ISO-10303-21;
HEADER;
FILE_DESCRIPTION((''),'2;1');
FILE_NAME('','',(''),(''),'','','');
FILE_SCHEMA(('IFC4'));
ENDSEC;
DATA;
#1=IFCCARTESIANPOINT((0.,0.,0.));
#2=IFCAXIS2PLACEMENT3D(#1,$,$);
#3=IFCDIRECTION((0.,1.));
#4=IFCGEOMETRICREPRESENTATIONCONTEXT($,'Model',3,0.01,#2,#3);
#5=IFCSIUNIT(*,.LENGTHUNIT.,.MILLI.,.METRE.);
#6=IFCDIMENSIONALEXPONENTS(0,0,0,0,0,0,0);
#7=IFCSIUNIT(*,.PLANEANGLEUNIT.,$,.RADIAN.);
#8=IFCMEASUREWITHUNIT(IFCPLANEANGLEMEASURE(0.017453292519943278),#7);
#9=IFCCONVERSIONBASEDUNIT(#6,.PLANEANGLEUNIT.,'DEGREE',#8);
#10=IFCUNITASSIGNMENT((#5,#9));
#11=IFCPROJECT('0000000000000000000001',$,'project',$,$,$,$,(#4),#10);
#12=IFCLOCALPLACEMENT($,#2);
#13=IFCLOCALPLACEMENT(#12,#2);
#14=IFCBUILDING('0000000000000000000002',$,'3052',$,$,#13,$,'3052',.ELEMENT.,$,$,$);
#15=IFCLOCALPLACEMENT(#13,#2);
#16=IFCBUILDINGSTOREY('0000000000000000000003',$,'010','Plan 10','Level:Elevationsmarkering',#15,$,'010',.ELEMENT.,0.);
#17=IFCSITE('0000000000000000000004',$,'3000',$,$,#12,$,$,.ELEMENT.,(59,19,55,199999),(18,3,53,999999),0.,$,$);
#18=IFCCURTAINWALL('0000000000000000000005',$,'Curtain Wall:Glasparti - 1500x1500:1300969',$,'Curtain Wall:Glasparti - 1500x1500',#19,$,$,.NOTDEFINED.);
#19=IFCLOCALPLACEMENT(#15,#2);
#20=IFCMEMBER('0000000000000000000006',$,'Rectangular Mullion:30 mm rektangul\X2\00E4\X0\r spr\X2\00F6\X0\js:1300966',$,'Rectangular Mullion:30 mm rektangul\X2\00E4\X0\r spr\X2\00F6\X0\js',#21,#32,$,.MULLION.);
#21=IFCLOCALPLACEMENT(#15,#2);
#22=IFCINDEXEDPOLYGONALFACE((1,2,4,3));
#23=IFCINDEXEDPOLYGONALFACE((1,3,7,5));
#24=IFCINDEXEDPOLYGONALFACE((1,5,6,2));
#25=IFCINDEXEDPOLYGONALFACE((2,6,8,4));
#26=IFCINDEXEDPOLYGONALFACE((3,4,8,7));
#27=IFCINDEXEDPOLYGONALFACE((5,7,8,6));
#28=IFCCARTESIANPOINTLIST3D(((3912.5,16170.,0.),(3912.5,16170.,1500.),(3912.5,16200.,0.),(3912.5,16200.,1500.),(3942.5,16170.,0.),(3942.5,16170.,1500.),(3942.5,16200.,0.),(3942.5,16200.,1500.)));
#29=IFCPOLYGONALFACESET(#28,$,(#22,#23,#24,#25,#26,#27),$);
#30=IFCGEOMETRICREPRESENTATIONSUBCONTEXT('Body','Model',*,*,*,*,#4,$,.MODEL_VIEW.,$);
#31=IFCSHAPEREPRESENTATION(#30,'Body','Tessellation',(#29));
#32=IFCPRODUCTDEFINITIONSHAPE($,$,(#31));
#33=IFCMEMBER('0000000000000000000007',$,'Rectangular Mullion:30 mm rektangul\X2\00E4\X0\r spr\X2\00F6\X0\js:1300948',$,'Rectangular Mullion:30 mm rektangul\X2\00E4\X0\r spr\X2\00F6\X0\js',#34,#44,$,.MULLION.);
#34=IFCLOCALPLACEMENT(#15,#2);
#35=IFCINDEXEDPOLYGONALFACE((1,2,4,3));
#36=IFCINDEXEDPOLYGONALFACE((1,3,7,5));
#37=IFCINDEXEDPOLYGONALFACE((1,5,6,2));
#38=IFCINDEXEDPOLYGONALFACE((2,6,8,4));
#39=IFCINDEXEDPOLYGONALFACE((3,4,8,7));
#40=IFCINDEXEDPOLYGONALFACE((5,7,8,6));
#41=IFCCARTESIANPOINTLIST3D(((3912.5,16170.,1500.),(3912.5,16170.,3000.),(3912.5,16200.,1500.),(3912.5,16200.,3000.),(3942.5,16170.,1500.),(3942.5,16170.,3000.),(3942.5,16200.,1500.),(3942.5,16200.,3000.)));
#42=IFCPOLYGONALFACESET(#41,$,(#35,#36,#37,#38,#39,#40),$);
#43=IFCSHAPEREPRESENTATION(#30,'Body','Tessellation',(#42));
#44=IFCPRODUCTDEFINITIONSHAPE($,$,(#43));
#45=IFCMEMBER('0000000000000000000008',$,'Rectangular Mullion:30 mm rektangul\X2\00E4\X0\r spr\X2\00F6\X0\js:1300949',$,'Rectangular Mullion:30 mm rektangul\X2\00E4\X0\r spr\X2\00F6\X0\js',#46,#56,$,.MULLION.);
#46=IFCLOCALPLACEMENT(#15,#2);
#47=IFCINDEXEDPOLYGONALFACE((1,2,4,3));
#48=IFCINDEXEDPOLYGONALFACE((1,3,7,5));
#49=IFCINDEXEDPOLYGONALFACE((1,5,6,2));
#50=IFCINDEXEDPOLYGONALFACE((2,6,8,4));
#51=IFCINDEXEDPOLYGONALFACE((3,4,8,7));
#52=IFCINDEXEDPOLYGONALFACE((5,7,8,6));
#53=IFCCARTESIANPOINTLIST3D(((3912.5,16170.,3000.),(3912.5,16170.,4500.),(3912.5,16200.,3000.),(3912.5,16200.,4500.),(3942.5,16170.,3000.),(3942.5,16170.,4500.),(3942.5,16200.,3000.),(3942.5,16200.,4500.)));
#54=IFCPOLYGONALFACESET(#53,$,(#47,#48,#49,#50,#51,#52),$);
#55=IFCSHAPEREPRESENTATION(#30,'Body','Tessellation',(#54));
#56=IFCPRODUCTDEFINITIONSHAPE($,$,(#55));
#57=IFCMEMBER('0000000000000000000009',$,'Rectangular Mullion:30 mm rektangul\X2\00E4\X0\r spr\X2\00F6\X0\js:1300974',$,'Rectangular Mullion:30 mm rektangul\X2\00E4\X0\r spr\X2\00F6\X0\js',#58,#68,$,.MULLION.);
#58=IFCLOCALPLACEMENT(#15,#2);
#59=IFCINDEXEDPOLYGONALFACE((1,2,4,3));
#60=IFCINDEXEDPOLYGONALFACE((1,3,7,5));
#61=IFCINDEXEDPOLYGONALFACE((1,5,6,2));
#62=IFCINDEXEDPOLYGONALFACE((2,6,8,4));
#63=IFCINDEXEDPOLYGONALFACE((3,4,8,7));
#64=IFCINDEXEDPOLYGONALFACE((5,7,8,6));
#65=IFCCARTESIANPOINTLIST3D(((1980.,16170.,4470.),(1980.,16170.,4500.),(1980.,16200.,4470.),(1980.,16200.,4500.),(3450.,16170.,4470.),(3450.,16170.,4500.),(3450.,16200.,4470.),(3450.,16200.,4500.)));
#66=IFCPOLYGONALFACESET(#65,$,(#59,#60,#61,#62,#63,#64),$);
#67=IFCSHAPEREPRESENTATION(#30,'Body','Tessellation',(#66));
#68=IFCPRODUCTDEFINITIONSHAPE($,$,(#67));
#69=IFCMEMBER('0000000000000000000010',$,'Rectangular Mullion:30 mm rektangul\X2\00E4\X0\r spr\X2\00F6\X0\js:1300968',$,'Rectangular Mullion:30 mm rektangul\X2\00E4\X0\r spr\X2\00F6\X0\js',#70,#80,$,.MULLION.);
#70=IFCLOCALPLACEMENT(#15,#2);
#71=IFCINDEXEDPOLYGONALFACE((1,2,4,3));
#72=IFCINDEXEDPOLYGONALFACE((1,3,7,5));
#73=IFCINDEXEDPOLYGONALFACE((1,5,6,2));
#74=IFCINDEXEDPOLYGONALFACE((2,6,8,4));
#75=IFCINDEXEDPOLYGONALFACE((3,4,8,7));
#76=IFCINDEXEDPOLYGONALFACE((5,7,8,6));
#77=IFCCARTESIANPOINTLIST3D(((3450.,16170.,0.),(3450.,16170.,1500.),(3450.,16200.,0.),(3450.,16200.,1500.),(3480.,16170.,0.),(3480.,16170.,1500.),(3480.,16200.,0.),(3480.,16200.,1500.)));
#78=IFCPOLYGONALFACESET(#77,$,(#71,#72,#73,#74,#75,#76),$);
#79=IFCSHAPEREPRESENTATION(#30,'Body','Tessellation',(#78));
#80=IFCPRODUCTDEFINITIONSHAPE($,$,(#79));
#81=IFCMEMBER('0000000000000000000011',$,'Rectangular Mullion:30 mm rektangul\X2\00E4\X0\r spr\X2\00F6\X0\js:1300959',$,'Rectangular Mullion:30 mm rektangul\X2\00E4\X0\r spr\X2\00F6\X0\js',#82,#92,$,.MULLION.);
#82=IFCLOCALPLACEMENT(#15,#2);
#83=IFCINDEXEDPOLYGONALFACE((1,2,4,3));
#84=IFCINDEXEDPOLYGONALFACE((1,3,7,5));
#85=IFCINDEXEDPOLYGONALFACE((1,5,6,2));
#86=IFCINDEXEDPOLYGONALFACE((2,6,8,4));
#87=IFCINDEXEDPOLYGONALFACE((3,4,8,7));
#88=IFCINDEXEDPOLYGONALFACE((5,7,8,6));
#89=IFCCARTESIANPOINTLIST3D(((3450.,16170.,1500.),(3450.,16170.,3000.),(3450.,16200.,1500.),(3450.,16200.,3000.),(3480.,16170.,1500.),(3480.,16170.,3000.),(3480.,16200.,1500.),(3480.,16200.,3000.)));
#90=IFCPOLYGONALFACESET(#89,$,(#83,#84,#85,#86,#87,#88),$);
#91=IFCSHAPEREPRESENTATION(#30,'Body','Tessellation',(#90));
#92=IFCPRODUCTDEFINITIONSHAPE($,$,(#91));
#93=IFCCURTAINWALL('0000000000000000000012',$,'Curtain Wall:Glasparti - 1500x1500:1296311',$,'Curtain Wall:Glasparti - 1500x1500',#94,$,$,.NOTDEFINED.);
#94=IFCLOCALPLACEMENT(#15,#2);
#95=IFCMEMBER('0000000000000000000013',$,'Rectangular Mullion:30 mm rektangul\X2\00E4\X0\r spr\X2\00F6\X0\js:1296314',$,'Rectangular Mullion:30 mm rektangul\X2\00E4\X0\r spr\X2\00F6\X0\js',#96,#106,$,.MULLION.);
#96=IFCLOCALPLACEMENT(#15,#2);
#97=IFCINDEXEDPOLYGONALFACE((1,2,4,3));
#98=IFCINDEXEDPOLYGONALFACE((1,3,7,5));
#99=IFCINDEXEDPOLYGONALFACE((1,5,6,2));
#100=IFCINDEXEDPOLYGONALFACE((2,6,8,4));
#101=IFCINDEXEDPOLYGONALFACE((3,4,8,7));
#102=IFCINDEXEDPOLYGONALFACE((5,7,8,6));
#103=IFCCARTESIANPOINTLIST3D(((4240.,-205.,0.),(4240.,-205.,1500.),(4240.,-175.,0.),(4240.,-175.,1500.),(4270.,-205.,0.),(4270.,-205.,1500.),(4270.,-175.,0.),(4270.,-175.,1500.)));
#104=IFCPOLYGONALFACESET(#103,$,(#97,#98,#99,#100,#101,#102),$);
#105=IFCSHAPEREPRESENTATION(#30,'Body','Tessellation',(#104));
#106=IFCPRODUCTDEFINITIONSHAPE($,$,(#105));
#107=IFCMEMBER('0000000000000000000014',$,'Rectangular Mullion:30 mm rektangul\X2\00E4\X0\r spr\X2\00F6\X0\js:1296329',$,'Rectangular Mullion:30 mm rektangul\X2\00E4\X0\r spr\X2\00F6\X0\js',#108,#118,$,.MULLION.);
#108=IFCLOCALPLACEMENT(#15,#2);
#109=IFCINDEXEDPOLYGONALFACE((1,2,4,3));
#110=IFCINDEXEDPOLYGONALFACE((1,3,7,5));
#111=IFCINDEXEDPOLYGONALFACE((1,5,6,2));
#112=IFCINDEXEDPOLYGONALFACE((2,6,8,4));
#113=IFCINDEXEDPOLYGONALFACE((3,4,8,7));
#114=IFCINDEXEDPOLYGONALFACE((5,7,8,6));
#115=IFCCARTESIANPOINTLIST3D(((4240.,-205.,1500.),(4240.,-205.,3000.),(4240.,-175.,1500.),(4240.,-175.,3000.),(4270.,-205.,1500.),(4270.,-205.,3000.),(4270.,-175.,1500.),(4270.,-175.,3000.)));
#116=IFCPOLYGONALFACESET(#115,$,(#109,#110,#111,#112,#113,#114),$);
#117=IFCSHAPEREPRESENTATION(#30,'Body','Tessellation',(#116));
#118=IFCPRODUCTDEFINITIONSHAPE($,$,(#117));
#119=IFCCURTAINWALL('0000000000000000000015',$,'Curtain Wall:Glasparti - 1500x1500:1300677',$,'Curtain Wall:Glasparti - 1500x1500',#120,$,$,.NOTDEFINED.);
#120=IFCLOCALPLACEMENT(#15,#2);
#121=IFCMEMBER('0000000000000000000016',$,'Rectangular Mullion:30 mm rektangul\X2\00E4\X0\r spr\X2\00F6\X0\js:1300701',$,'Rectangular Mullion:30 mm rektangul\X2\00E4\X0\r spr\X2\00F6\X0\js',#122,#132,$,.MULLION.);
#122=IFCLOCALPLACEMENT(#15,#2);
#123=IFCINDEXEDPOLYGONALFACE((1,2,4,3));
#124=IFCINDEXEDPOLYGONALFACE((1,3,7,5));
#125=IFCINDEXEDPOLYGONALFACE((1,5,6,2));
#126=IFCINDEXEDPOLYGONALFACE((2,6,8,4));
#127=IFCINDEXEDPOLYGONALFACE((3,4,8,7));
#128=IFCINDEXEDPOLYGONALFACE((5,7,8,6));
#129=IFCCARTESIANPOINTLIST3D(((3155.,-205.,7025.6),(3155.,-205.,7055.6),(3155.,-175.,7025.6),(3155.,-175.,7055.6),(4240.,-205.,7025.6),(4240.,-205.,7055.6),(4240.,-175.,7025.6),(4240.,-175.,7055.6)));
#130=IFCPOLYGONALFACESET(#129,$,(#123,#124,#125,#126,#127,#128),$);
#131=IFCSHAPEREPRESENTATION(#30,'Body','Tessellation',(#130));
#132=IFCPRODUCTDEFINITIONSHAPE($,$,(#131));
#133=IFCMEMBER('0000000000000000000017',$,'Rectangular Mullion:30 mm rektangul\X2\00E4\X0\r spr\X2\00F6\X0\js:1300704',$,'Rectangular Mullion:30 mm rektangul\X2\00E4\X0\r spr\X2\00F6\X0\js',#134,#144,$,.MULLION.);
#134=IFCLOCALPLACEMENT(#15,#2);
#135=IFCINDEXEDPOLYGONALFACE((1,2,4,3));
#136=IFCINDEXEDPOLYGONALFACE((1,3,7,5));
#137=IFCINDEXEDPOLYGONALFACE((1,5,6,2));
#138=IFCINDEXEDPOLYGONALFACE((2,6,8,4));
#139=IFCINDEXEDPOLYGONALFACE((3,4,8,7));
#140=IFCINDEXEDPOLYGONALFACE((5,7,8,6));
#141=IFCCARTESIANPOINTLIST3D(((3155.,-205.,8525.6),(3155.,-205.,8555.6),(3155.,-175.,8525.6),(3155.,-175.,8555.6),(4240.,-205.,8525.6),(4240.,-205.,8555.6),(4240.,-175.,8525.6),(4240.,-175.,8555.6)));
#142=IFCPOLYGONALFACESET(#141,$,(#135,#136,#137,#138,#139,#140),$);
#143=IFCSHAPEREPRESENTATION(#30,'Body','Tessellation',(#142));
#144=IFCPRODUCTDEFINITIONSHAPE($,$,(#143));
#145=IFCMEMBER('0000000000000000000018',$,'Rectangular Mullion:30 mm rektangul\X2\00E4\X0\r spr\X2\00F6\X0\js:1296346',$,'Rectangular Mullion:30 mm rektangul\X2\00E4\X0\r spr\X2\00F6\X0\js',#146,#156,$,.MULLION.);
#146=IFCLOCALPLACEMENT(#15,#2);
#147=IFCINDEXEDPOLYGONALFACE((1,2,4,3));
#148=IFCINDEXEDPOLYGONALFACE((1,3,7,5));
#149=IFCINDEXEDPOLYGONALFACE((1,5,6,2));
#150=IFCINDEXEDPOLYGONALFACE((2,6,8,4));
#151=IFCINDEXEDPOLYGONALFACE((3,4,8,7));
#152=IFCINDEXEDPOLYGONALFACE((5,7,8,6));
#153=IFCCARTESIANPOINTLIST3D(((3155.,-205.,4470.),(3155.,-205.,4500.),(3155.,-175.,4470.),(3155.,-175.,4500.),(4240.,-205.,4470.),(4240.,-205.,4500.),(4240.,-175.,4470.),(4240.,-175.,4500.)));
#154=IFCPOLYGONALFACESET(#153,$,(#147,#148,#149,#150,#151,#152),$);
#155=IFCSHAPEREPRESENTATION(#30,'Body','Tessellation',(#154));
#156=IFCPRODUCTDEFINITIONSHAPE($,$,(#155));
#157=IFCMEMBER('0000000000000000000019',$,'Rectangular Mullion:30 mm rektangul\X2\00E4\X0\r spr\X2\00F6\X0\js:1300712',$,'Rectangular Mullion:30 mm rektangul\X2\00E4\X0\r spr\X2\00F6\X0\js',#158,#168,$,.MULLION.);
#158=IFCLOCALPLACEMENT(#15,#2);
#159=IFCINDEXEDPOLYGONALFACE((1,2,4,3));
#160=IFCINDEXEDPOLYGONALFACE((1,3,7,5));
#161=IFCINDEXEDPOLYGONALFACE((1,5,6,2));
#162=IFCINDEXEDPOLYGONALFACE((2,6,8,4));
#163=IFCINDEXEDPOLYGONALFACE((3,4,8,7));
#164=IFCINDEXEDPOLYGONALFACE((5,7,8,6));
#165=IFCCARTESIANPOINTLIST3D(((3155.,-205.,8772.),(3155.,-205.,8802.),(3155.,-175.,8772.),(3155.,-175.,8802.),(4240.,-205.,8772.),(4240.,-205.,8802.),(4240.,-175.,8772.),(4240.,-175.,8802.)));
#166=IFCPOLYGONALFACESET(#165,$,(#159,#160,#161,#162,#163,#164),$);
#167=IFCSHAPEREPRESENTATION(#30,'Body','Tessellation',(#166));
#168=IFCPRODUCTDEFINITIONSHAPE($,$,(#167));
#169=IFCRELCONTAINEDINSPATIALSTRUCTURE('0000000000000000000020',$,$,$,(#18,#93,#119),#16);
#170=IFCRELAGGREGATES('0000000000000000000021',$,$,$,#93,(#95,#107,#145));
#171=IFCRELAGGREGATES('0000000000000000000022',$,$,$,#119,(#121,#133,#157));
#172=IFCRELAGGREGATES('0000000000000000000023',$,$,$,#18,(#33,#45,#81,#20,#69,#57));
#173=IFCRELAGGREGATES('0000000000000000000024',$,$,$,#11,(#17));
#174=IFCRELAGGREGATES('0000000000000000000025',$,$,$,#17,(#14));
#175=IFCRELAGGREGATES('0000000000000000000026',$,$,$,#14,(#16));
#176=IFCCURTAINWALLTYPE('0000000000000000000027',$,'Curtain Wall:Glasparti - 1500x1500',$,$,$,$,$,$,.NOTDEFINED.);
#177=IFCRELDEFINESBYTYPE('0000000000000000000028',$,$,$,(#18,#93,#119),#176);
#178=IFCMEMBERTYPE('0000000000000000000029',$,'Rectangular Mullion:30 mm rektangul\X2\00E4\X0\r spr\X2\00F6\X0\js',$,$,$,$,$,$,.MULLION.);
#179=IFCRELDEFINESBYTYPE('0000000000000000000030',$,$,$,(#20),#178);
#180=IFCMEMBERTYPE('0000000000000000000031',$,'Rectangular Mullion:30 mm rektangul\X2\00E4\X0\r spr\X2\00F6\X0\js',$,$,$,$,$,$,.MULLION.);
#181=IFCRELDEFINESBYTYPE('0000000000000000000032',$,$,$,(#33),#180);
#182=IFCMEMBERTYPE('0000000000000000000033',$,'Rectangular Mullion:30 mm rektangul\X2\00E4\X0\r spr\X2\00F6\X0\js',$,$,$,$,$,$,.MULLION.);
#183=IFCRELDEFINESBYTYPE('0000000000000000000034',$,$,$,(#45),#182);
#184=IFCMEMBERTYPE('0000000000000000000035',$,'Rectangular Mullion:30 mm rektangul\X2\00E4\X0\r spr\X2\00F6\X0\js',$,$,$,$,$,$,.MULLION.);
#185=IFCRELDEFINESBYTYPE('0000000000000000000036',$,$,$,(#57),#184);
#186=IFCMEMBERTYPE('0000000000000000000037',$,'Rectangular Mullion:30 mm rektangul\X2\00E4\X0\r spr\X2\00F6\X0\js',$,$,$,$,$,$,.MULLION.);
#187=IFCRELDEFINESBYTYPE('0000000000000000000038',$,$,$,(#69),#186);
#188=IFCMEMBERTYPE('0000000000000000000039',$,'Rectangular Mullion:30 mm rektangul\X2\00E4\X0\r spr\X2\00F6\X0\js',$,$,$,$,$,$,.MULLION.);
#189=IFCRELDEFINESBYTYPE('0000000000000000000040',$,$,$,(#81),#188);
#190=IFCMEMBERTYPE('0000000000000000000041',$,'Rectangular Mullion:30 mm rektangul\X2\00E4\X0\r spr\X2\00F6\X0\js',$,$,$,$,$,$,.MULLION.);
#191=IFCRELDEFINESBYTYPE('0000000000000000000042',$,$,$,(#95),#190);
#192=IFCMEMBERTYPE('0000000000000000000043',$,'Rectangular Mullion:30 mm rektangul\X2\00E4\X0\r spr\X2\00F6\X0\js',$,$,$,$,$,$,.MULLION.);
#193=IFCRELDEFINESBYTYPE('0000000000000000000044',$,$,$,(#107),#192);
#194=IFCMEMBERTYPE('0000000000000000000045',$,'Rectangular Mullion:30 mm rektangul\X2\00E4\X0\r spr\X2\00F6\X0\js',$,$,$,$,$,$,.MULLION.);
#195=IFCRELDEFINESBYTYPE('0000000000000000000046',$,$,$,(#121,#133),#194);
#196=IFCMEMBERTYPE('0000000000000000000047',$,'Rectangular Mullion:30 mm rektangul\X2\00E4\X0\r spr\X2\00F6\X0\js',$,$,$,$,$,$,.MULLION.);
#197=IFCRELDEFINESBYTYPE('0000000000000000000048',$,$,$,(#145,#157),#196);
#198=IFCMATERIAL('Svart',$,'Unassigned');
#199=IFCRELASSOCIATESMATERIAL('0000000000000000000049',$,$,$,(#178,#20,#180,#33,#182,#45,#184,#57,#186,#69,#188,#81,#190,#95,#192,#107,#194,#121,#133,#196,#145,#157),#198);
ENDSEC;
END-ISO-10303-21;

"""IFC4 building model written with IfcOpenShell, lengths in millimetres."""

from ifc_helpers import new_model, entity, si_unit, converted_unit, direction, frame, origin, place, context, subcontext, project, spatial, indexed_curve, outline, extrude, source, transform, mapped, material, type_object, type_shapes, element, aggregate, save


model = new_model("IFC4")

# Units and contexts
model_context = context("Model", 3, precision=0.01, world=origin(), true_north=direction((0.0, 1.0)))
body_context = subcontext(model_context, "Body", "Model", "MODEL_VIEW")
ifc_project = project(units=[si_unit("LENGTHUNIT", "METRE", prefix="MILLI"), converted_unit("PLANEANGLEUNIT", "DEGREE", entity("IfcPlaneAngleMeasure", 0.017453292519943278), si_unit("PLANEANGLEUNIT", "RADIAN"), dimensions=[0, 0, 0, 0, 0, 0, 0])], contexts=[model_context])

# Site, building, storey
site_placement = place(None, origin())
site = spatial("IfcSite", under=ifc_project, at=site_placement, Name="3000", CompositionType="ELEMENT", RefLatitude=(59, 19, 55, 199999), RefLongitude=(18, 3, 53, 999999), RefElevation=0.0)
building_placement = place(site_placement, origin())
building = spatial("IfcBuilding", under=site, at=building_placement, Name="3052", LongName="3052", CompositionType="ELEMENT")
storey_placement = place(building_placement, origin())
storey = spatial("IfcBuildingStorey", under=building, at=storey_placement, Name="010", Description="Plan 10", ObjectType="Level:Elevationsmarkering", LongName="010", CompositionType="ELEMENT", Elevation=0.0)

# Curtain walls, members
curtain_wall_type = type_object("IfcCurtainWallType", Name="Curtain Wall:Glasparti - 1500x1500", PredefinedType="NOTDEFINED")
curtain_wall_1_placement = place(storey_placement, origin())
curtain_wall_1 = element("IfcCurtainWall", 1, at=curtain_wall_1_placement, inside=storey, type_object=curtain_wall_type, Name="Curtain Wall:Glasparti - 1500x1500:1300969", ObjectType="Curtain Wall:Glasparti - 1500x1500", PredefinedType="NOTDEFINED")
ifc_material_1 = material(Name="Svart", Category="Unassigned")
member_type_1 = type_object("IfcMemberType", Name="Rectangular Mullion:30 mm rektangulär spröjs", PredefinedType="MULLION", material=ifc_material_1)
shared_shape_1 = source(origin(), body_context, "Body", "SweptSolid", [
    extrude(outline(indexed_curve([(-15.0, -15.0), (15.0, -15.0), (15.0, 15.0), (-15.0, 15.0), (-15.0, -15.0)], self_intersect=False)), frame((-15.0, 0.0, -1500.0), z_axis=(0.0, 0.0, 1.0), x_axis=(-1.0, 0.0, 0.0)), (0.0, 0.0, 1.0), 1500.0),
])
type_shapes(member_type_1, [shared_shape_1])
member_1_placement = place(curtain_wall_1_placement, frame((3942.5, 16185.0, 0.0), z_axis=(0.0, 0.0, -1.0), x_axis=(1.0, 0.0, 0.0)))
member_1 = element("IfcMember", 2, at=member_1_placement, type_object=member_type_1, material=ifc_material_1, Name="Rectangular Mullion:30 mm rektangulär spröjs:1300966", ObjectType="Rectangular Mullion:30 mm rektangulär spröjs", PredefinedType="MULLION", context=body_context, shape_type="MappedRepresentation", body=[
    mapped(shared_shape_1, transform((0.0, 0.0, 0.0), scale=1.0)),
])
member_type_2 = type_object("IfcMemberType", Name="Rectangular Mullion:30 mm rektangulär spröjs", PredefinedType="MULLION", material=ifc_material_1)
shared_shape_2 = source(origin(), body_context, "Body", "SweptSolid", [
    extrude(outline(indexed_curve([(-15.0, -15.0), (15.0, -15.0), (15.0, 15.0), (-15.0, 15.0), (-15.0, -15.0)], self_intersect=False)), frame((-15.0, 0.0, -1500.0), z_axis=(0.0, 0.0, 1.0), x_axis=(-1.0, 0.0, 0.0)), (0.0, 0.0, 1.0), 1500.0),
])
type_shapes(member_type_2, [shared_shape_2])
member_2_placement = place(curtain_wall_1_placement, frame((3942.5, 16185.0, 1500.0), z_axis=(0.0, 0.0, -1.0), x_axis=(1.0, 0.0, 0.0)))
member_2 = element("IfcMember", 3, at=member_2_placement, type_object=member_type_2, material=ifc_material_1, Name="Rectangular Mullion:30 mm rektangulär spröjs:1300948", ObjectType="Rectangular Mullion:30 mm rektangulär spröjs", PredefinedType="MULLION", context=body_context, shape_type="MappedRepresentation", body=[
    mapped(shared_shape_2, transform((0.0, 0.0, 0.0), scale=1.0)),
])
member_type_3 = type_object("IfcMemberType", Name="Rectangular Mullion:30 mm rektangulär spröjs", PredefinedType="MULLION", material=ifc_material_1)
shared_shape_3 = source(origin(), body_context, "Body", "SweptSolid", [
    extrude(outline(indexed_curve([(-15.0, -15.0), (15.0, -15.0), (15.0, 15.0), (-15.0, 15.0), (-15.0, -15.0)], self_intersect=False)), frame((-15.0, 0.0, -1500.0), z_axis=(0.0, 0.0, 1.0), x_axis=(-1.0, 0.0, 0.0)), (0.0, 0.0, 1.0), 1500.0),
])
type_shapes(member_type_3, [shared_shape_3])
member_3_placement = place(curtain_wall_1_placement, frame((3942.5, 16185.0, 3000.0), z_axis=(0.0, 0.0, -1.0), x_axis=(1.0, 0.0, 0.0)))
member_3 = element("IfcMember", 4, at=member_3_placement, type_object=member_type_3, material=ifc_material_1, Name="Rectangular Mullion:30 mm rektangulär spröjs:1300949", ObjectType="Rectangular Mullion:30 mm rektangulär spröjs", PredefinedType="MULLION", context=body_context, shape_type="MappedRepresentation", body=[
    mapped(shared_shape_3, transform((0.0, 0.0, 0.0), scale=1.0)),
])
member_type_4 = type_object("IfcMemberType", Name="Rectangular Mullion:30 mm rektangulär spröjs", PredefinedType="MULLION", material=ifc_material_1)
shared_shape_4 = source(origin(), body_context, "Body", "SweptSolid", [
    extrude(outline(indexed_curve([(-15.0, -15.0), (15.0, -15.0), (15.0, 15.0), (-15.0, 15.0), (-15.0, -15.0)], self_intersect=False)), frame((-15.0, 0.0, -1470.0), z_axis=(0.0, 0.0, 1.0), x_axis=(-1.0, 0.0, 0.0)), (0.0, 0.0, 1.0), 1470.0),
])
type_shapes(member_type_4, [shared_shape_4])
member_4_placement = place(curtain_wall_1_placement, frame((3450.0, 16185.0, 4500.0), z_axis=(1.0, 0.0, 0.0), x_axis=(0.0, 0.0, 1.0)))
member_4 = element("IfcMember", 5, at=member_4_placement, type_object=member_type_4, material=ifc_material_1, Name="Rectangular Mullion:30 mm rektangulär spröjs:1300974", ObjectType="Rectangular Mullion:30 mm rektangulär spröjs", PredefinedType="MULLION", context=body_context, shape_type="MappedRepresentation", body=[
    mapped(shared_shape_4, transform((0.0, 0.0, 0.0), scale=1.0)),
])
member_type_5 = type_object("IfcMemberType", Name="Rectangular Mullion:30 mm rektangulär spröjs", PredefinedType="MULLION", material=ifc_material_1)
shared_shape_5 = source(origin(), body_context, "Body", "SweptSolid", [
    extrude(outline(indexed_curve([(-15.0, -15.0), (15.0, -15.0), (15.0, 15.0), (-15.0, 15.0), (-15.0, -15.0)], self_intersect=False)), frame((0.0, 0.0, -1500.0), z_axis=(0.0, 0.0, 1.0), x_axis=(-1.0, 0.0, 0.0)), (0.0, 0.0, 1.0), 1500.0),
])
type_shapes(member_type_5, [shared_shape_5])
member_5_placement = place(curtain_wall_1_placement, frame((3465.0, 16185.0, 0.0), z_axis=(0.0, 0.0, -1.0), x_axis=(1.0, 0.0, 0.0)))
member_5 = element("IfcMember", 6, at=member_5_placement, type_object=member_type_5, material=ifc_material_1, Name="Rectangular Mullion:30 mm rektangulär spröjs:1300968", ObjectType="Rectangular Mullion:30 mm rektangulär spröjs", PredefinedType="MULLION", context=body_context, shape_type="MappedRepresentation", body=[
    mapped(shared_shape_5, transform((0.0, 0.0, 0.0), scale=1.0)),
])
member_type_6 = type_object("IfcMemberType", Name="Rectangular Mullion:30 mm rektangulär spröjs", PredefinedType="MULLION", material=ifc_material_1)
shared_shape_6 = source(origin(), body_context, "Body", "SweptSolid", [
    extrude(outline(indexed_curve([(-15.0, -15.0), (15.0, -15.0), (15.0, 15.0), (-15.0, 15.0), (-15.0, -15.0)], self_intersect=False)), frame((0.0, 0.0, -1500.0), z_axis=(0.0, 0.0, 1.0), x_axis=(-1.0, 0.0, 0.0)), (0.0, 0.0, 1.0), 1500.0),
])
type_shapes(member_type_6, [shared_shape_6])
member_6_placement = place(curtain_wall_1_placement, frame((3465.0, 16185.0, 1500.0), z_axis=(0.0, 0.0, -1.0), x_axis=(1.0, 0.0, 0.0)))
member_6 = element("IfcMember", 7, at=member_6_placement, type_object=member_type_6, material=ifc_material_1, Name="Rectangular Mullion:30 mm rektangulär spröjs:1300959", ObjectType="Rectangular Mullion:30 mm rektangulär spröjs", PredefinedType="MULLION", context=body_context, shape_type="MappedRepresentation", body=[
    mapped(shared_shape_6, transform((0.0, 0.0, 0.0), scale=1.0)),
])
curtain_wall_2_placement = place(storey_placement, origin())
curtain_wall_2 = element("IfcCurtainWall", 8, at=curtain_wall_2_placement, inside=storey, type_object=curtain_wall_type, Name="Curtain Wall:Glasparti - 1500x1500:1296311", ObjectType="Curtain Wall:Glasparti - 1500x1500", PredefinedType="NOTDEFINED")
member_type_7 = type_object("IfcMemberType", Name="Rectangular Mullion:30 mm rektangulär spröjs", PredefinedType="MULLION", material=ifc_material_1)
shared_shape_7 = source(origin(), body_context, "Body", "SweptSolid", [
    extrude(outline(indexed_curve([(-15.0, -15.0), (15.0, -15.0), (15.0, 15.0), (-15.0, 15.0), (-15.0, -15.0)], self_intersect=False)), frame((-15.0, 0.0, -1500.0), z_axis=(0.0, 0.0, 1.0), x_axis=(-1.0, 0.0, 0.0)), (0.0, 0.0, 1.0), 1500.0),
])
type_shapes(member_type_7, [shared_shape_7])
member_7_placement = place(curtain_wall_2_placement, frame((4270.0, -190.0, 0.0), z_axis=(0.0, 0.0, -1.0), x_axis=(1.0, 0.0, 0.0)))
member_7 = element("IfcMember", 9, at=member_7_placement, type_object=member_type_7, material=ifc_material_1, Name="Rectangular Mullion:30 mm rektangulär spröjs:1296314", ObjectType="Rectangular Mullion:30 mm rektangulär spröjs", PredefinedType="MULLION", context=body_context, shape_type="MappedRepresentation", body=[
    mapped(shared_shape_7, transform((0.0, 0.0, 0.0), scale=1.0)),
])
member_type_8 = type_object("IfcMemberType", Name="Rectangular Mullion:30 mm rektangulär spröjs", PredefinedType="MULLION", material=ifc_material_1)
shared_shape_8 = source(origin(), body_context, "Body", "SweptSolid", [
    extrude(outline(indexed_curve([(-15.0, -15.0), (15.0, -15.0), (15.0, 15.0), (-15.0, 15.0), (-15.0, -15.0)], self_intersect=False)), frame((-15.0, 0.0, -1500.0), z_axis=(0.0, 0.0, 1.0), x_axis=(-1.0, 0.0, 0.0)), (0.0, 0.0, 1.0), 1500.0),
])
type_shapes(member_type_8, [shared_shape_8])
member_8_placement = place(curtain_wall_2_placement, frame((4270.0, -190.0, 1500.0), z_axis=(0.0, 0.0, -1.0), x_axis=(1.0, 0.0, 0.0)))
member_8 = element("IfcMember", 10, at=member_8_placement, type_object=member_type_8, material=ifc_material_1, Name="Rectangular Mullion:30 mm rektangulär spröjs:1296329", ObjectType="Rectangular Mullion:30 mm rektangulär spröjs", PredefinedType="MULLION", context=body_context, shape_type="MappedRepresentation", body=[
    mapped(shared_shape_8, transform((0.0, 0.0, 0.0), scale=1.0)),
])
curtain_wall_3_placement = place(storey_placement, origin())
curtain_wall_3 = element("IfcCurtainWall", 11, at=curtain_wall_3_placement, inside=storey, type_object=curtain_wall_type, Name="Curtain Wall:Glasparti - 1500x1500:1300677", ObjectType="Curtain Wall:Glasparti - 1500x1500", PredefinedType="NOTDEFINED")
member_type_9 = type_object("IfcMemberType", Name="Rectangular Mullion:30 mm rektangulär spröjs", PredefinedType="MULLION", material=ifc_material_1)
shared_shape_9 = source(origin(), body_context, "Body", "SweptSolid", [
    extrude(outline(indexed_curve([(-15.0, -15.0), (15.0, -15.0), (15.0, 15.0), (-15.0, 15.0), (-15.0, -15.0)], self_intersect=False)), frame((0.0, 0.0, -1085.0), z_axis=(0.0, 0.0, 1.0), x_axis=(-1.0, 0.0, 0.0)), (0.0, 0.0, 1.0), 1085.0),
])
type_shapes(member_type_9, [shared_shape_9])
member_9_placement = place(curtain_wall_3_placement, frame((4240.0, -190.0, 7040.6), z_axis=(1.0, 0.0, 0.0), x_axis=(0.0, 0.0, 1.0)))
member_9 = element("IfcMember", 12, at=member_9_placement, type_object=member_type_9, material=ifc_material_1, Name="Rectangular Mullion:30 mm rektangulär spröjs:1300701", ObjectType="Rectangular Mullion:30 mm rektangulär spröjs", PredefinedType="MULLION", context=body_context, shape_type="MappedRepresentation", body=[
    mapped(shared_shape_9, transform((0.0, 0.0, 0.0), scale=1.0)),
])
member_10_placement = place(curtain_wall_3_placement, frame((4240.0, -190.0, 8540.6), z_axis=(1.0, 0.0, 0.0), x_axis=(0.0, 0.0, 1.0)))
member_10 = element("IfcMember", 13, at=member_10_placement, type_object=member_type_9, material=ifc_material_1, Name="Rectangular Mullion:30 mm rektangulär spröjs:1300704", ObjectType="Rectangular Mullion:30 mm rektangulär spröjs", PredefinedType="MULLION", context=body_context, shape_type="MappedRepresentation", body=[
    mapped(shared_shape_9, transform((0.0, 0.0, 0.0), scale=1.0)),
])

# Members
member_type_10 = type_object("IfcMemberType", Name="Rectangular Mullion:30 mm rektangulär spröjs", PredefinedType="MULLION", material=ifc_material_1)
shared_shape_10 = source(origin(), body_context, "Body", "SweptSolid", [
    extrude(outline(indexed_curve([(-15.0, -15.0), (15.0, -15.0), (15.0, 15.0), (-15.0, 15.0), (-15.0, -15.0)], self_intersect=False)), frame((-15.0, 0.0, -1085.0), z_axis=(0.0, 0.0, 1.0), x_axis=(-1.0, 0.0, 0.0)), (0.0, 0.0, 1.0), 1085.0),
])
type_shapes(member_type_10, [shared_shape_10])
member_11_placement = place(curtain_wall_2_placement, frame((4240.0, -190.0, 4500.0), z_axis=(1.0, 0.0, 0.0), x_axis=(0.0, 0.0, 1.0)))
member_11 = element("IfcMember", 14, at=member_11_placement, type_object=member_type_10, material=ifc_material_1, Name="Rectangular Mullion:30 mm rektangulär spröjs:1296346", ObjectType="Rectangular Mullion:30 mm rektangulär spröjs", PredefinedType="MULLION", context=body_context, shape_type="MappedRepresentation", body=[
    mapped(shared_shape_10, transform((0.0, 0.0, 0.0), scale=1.0)),
])
aggregate(curtain_wall_2, [member_7, member_8, member_11])
member_12_placement = place(curtain_wall_3_placement, frame((4240.0, -190.0, 8802.0), z_axis=(1.0, 0.0, 0.0), x_axis=(0.0, 0.0, 1.0)))
member_12 = element("IfcMember", 15, at=member_12_placement, type_object=member_type_10, material=ifc_material_1, Name="Rectangular Mullion:30 mm rektangulär spröjs:1300712", ObjectType="Rectangular Mullion:30 mm rektangulär spröjs", PredefinedType="MULLION", context=body_context, shape_type="MappedRepresentation", body=[
    mapped(shared_shape_10, transform((0.0, 0.0, 0.0), scale=1.0)),
])
aggregate(curtain_wall_3, [member_9, member_10, member_12])

aggregate(curtain_wall_1, [member_2, member_3, member_6, member_1, member_5, member_4])

save(model, "model.ifc")
